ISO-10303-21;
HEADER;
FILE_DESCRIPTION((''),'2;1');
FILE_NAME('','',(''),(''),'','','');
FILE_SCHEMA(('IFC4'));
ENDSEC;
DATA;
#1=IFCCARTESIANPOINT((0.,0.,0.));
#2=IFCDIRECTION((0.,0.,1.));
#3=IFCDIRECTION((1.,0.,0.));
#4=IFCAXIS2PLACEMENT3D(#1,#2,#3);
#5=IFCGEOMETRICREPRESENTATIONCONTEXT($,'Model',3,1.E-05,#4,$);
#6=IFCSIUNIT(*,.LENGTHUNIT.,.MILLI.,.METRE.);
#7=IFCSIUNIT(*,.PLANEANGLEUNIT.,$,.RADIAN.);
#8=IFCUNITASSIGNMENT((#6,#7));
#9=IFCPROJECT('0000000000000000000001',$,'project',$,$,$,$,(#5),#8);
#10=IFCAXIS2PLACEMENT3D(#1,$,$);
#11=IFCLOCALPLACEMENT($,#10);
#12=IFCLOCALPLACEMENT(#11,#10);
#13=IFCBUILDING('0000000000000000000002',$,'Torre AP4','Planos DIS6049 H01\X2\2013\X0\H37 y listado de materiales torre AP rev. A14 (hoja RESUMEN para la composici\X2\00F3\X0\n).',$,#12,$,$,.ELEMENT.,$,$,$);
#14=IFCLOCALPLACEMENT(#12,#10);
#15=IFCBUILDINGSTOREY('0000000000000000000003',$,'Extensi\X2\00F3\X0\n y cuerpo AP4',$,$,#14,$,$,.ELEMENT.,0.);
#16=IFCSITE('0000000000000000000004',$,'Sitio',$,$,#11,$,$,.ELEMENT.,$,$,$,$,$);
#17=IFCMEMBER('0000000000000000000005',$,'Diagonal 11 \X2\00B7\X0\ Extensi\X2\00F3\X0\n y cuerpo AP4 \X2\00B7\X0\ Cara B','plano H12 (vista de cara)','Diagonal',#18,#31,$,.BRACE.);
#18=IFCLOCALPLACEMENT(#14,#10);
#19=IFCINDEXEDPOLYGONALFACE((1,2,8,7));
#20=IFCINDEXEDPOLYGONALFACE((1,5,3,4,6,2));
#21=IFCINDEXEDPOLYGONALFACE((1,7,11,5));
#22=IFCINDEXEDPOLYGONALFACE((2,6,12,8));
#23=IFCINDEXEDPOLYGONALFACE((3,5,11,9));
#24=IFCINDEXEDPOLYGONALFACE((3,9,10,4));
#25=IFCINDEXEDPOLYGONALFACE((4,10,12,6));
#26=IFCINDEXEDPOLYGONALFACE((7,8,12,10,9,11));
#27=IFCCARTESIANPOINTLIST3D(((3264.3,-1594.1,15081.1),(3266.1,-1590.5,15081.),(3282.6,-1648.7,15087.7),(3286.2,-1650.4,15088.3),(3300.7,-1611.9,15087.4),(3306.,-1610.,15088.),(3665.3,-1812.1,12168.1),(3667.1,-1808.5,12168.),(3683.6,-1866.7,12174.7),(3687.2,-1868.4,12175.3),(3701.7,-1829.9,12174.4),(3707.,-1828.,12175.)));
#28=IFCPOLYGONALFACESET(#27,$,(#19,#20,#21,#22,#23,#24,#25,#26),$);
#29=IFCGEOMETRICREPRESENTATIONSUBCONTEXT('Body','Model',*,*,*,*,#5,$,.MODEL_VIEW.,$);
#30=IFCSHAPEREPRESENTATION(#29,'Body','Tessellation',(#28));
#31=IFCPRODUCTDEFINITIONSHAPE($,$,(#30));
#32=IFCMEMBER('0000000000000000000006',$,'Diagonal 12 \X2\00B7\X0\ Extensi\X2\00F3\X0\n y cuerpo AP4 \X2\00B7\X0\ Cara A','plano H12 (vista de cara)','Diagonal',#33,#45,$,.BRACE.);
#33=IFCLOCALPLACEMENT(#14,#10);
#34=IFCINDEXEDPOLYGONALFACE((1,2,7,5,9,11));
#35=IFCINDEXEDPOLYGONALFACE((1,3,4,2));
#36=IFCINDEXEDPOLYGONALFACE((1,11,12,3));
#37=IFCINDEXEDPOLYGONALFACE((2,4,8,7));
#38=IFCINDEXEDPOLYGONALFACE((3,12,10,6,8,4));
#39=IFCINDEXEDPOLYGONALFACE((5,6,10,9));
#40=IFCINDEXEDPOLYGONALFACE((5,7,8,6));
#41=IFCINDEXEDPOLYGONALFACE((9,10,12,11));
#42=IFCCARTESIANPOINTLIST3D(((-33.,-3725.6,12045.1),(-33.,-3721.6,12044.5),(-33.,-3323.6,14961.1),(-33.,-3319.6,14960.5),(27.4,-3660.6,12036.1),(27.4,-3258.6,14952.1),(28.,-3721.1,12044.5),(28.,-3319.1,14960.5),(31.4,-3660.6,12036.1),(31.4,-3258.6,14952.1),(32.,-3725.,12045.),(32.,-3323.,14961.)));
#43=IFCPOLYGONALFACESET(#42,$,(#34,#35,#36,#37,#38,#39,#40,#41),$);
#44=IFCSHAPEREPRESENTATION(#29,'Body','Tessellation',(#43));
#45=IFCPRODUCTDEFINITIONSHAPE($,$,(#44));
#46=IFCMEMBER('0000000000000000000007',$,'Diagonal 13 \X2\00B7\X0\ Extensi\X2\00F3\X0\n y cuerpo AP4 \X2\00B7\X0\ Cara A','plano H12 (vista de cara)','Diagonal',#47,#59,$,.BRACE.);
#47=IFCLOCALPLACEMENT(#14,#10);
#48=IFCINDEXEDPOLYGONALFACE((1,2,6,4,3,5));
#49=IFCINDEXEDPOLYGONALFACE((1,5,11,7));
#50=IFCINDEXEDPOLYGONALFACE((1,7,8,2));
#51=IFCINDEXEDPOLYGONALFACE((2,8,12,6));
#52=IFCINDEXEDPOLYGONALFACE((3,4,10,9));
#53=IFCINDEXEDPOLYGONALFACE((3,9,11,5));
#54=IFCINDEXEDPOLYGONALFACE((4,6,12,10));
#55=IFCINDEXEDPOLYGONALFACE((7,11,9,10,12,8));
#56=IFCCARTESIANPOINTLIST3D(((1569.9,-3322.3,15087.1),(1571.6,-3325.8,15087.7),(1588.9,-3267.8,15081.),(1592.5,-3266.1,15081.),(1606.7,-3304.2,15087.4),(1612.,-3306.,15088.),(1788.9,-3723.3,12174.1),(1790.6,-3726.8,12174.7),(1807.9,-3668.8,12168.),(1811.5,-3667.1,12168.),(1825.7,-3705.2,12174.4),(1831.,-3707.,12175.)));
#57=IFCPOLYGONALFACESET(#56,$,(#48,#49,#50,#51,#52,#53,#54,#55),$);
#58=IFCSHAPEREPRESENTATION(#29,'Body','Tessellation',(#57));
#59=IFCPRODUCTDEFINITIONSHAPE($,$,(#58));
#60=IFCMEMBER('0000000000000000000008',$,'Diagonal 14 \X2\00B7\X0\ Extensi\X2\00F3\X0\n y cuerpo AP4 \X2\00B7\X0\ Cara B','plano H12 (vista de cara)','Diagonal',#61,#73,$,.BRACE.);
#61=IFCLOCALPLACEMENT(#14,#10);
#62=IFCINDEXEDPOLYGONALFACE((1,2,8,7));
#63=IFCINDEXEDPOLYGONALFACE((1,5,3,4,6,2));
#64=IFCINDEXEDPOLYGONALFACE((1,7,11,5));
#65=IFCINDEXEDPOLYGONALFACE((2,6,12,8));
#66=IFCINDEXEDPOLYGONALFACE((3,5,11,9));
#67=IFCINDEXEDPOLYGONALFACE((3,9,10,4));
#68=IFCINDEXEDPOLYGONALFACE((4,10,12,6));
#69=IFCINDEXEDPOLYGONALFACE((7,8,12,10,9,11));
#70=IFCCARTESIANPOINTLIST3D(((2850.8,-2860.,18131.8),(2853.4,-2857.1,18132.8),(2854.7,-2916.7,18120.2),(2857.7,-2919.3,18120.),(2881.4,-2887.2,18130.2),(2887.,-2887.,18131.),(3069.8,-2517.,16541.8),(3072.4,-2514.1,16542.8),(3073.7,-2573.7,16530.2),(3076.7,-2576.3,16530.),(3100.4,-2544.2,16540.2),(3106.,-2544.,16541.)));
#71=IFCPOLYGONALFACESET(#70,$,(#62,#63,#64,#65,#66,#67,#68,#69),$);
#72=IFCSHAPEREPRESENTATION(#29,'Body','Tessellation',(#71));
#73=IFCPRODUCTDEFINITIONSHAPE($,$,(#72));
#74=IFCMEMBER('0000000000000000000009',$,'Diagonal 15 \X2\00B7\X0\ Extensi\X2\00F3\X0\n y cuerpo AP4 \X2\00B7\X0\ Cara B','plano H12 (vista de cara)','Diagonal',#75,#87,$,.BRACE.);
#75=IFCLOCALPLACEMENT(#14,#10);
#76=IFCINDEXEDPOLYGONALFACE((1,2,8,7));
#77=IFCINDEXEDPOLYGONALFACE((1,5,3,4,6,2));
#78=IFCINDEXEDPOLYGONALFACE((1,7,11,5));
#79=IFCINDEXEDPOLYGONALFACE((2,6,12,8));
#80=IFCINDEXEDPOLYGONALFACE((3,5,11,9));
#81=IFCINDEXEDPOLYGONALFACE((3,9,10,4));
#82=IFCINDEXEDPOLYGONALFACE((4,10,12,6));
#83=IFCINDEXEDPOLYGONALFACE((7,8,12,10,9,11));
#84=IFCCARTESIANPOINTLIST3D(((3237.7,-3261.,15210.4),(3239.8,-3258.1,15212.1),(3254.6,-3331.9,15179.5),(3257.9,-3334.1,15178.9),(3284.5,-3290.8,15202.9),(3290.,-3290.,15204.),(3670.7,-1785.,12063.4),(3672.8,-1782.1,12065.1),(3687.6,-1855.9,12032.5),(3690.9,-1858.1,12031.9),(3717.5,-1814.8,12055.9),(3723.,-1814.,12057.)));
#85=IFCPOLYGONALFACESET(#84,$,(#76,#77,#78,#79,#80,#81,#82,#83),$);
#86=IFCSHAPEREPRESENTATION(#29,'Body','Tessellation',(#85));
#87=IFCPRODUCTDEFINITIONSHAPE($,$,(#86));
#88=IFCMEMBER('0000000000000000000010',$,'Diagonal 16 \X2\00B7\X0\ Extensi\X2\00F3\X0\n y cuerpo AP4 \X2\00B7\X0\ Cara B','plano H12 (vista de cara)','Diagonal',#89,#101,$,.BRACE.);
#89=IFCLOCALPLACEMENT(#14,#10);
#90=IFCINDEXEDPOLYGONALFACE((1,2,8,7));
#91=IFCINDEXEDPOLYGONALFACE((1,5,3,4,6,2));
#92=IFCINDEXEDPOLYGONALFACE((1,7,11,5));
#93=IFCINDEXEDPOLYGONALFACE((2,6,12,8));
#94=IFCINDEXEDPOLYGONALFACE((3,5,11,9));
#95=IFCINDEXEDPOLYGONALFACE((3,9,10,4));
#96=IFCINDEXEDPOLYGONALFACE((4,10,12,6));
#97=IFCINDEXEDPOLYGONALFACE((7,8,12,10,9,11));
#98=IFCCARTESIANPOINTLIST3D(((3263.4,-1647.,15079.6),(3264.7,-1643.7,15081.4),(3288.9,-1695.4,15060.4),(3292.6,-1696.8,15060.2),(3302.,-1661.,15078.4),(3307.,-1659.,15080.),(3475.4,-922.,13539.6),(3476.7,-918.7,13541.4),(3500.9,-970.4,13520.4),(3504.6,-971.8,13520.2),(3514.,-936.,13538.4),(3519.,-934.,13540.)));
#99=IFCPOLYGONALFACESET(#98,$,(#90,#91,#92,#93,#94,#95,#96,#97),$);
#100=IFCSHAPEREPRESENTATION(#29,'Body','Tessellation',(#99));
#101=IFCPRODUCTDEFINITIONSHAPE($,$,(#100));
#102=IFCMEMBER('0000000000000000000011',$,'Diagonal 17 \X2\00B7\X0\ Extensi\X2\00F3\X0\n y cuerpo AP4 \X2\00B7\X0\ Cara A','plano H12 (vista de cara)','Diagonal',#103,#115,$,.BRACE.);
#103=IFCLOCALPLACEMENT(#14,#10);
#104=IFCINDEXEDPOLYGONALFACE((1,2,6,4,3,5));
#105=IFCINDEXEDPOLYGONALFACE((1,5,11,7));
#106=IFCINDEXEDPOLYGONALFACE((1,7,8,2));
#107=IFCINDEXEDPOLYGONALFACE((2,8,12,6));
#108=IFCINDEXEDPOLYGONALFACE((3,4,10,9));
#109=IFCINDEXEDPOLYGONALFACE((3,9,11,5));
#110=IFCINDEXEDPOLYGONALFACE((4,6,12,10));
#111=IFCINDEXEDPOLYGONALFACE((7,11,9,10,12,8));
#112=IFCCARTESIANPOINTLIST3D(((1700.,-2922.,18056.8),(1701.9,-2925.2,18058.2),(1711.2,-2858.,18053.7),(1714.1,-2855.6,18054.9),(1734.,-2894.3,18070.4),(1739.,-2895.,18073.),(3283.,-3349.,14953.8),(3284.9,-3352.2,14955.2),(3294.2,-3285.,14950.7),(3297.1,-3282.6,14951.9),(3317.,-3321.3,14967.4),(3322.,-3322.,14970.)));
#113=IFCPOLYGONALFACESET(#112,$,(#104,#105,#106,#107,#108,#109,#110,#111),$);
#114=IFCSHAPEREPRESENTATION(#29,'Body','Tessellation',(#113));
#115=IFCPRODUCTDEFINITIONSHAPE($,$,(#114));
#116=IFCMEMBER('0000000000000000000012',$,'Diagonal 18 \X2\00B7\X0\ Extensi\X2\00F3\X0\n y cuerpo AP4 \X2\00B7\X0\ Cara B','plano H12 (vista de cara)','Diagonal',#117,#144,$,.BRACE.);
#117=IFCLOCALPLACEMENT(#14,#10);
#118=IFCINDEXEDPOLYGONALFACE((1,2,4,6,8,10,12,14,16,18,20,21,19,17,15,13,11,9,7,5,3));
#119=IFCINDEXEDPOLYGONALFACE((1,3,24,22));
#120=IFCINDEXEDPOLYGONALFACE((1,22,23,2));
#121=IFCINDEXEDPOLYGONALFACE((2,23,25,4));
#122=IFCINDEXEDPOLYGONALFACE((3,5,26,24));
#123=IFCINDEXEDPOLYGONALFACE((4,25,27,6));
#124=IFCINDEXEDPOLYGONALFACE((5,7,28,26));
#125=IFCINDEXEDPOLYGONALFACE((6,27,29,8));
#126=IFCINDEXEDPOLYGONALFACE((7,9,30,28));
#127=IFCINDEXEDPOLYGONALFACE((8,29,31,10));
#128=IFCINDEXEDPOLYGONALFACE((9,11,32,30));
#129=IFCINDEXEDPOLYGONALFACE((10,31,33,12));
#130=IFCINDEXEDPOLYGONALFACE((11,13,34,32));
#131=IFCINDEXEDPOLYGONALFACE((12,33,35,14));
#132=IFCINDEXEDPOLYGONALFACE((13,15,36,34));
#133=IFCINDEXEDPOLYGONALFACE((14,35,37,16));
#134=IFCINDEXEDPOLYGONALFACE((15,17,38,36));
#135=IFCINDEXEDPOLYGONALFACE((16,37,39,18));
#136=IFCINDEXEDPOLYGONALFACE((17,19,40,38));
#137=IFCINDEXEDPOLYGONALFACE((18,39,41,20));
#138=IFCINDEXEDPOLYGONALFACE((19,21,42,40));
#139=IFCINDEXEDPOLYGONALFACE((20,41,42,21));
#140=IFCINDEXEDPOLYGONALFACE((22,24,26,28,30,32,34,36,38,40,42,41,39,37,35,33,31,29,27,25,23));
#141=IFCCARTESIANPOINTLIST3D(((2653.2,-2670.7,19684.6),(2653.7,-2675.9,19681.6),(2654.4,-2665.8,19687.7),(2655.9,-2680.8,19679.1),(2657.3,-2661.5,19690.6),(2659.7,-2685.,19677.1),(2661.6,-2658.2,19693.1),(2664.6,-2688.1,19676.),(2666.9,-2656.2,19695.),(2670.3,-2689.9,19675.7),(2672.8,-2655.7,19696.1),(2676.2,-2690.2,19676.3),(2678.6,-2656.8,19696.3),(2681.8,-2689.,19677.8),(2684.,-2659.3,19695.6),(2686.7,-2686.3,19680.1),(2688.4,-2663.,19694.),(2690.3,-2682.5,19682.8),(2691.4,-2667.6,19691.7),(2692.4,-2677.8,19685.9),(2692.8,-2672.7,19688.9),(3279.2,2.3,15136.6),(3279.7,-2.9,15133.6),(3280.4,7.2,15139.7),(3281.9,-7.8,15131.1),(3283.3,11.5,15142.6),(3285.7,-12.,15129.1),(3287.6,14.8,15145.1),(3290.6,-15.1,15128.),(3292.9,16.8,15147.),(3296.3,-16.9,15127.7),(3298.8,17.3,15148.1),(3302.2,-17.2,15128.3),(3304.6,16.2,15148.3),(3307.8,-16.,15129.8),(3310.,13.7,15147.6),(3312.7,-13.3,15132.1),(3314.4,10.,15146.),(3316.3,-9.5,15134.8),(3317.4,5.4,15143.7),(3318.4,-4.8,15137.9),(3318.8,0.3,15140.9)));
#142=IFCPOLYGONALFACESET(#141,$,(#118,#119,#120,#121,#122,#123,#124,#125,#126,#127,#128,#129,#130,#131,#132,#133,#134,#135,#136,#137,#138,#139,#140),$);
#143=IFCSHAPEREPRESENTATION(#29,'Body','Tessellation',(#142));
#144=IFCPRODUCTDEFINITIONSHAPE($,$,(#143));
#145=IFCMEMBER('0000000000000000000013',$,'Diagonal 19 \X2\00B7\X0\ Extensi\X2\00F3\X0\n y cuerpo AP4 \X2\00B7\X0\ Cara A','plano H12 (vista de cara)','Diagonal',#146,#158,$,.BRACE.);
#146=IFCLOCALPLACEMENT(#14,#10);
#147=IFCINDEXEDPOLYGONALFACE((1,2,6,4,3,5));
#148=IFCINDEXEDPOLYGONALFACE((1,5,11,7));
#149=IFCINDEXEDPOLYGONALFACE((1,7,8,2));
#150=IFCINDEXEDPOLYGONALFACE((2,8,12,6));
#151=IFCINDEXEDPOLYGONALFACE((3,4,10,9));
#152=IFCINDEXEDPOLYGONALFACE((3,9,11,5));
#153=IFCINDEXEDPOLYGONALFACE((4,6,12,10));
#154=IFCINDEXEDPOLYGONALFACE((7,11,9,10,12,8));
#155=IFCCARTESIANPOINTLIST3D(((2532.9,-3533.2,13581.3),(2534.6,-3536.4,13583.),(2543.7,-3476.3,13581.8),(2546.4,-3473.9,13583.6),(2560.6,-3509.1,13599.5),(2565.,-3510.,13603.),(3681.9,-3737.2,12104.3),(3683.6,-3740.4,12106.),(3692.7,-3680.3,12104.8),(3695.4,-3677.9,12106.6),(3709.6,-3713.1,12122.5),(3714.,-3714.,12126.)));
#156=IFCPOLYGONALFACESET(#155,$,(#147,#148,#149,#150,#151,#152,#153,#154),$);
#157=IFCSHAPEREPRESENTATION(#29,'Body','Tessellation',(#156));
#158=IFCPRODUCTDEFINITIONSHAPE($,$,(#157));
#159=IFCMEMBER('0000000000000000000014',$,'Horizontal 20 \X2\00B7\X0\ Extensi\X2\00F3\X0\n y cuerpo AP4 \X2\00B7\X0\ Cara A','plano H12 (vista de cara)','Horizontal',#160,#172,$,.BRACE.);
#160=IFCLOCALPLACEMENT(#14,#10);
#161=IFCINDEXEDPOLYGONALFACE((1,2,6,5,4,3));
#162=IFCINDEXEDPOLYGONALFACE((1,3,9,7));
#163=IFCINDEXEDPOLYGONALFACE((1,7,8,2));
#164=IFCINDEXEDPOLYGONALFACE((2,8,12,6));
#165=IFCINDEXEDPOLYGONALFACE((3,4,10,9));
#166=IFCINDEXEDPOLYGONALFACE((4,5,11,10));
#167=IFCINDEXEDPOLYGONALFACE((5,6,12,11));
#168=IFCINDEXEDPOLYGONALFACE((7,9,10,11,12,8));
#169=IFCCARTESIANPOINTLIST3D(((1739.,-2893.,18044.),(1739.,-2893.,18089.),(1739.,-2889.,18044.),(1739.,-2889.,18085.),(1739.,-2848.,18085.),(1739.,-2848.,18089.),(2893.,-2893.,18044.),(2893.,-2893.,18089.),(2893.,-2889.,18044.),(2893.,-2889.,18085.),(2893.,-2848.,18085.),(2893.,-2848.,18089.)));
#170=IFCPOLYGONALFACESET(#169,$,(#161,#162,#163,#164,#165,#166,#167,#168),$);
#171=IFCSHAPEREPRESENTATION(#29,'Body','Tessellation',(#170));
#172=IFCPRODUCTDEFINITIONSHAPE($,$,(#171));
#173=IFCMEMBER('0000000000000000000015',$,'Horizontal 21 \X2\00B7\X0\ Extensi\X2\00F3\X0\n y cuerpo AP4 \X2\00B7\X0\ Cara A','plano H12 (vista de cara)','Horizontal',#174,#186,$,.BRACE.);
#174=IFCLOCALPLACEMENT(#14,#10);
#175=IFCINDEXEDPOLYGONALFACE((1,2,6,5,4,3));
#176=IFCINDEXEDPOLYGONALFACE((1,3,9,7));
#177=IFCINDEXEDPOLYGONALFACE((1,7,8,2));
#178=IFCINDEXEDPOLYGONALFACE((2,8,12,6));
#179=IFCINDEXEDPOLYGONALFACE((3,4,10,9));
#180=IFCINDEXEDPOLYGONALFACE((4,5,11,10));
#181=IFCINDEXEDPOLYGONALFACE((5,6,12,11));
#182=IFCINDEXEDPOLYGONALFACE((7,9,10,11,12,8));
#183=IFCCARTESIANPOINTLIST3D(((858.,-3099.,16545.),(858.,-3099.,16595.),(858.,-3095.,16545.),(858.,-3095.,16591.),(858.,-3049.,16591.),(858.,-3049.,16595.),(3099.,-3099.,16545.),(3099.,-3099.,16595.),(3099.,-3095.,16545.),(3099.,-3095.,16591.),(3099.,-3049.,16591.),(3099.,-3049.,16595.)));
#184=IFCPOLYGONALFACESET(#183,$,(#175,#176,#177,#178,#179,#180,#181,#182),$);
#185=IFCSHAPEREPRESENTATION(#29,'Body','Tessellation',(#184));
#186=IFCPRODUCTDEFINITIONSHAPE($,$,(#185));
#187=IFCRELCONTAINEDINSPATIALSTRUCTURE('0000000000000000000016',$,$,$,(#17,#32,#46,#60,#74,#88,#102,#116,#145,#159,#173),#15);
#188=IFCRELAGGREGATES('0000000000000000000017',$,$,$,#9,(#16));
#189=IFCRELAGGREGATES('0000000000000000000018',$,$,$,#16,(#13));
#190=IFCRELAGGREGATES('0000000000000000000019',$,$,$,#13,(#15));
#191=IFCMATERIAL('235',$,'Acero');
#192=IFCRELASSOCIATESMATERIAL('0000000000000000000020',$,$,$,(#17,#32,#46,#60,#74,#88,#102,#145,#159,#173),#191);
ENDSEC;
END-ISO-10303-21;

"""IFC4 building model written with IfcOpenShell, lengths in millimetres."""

from ifc_helpers import new_model, si_unit, frame, frame_2d, origin, origin_with_axes, place, context, subcontext, project, spatial, circle, l_section, extrude, material, element, save


model = new_model("IFC4")

# Units and contexts
model_context = context("Model", 3, precision=1e-05, world=origin_with_axes())
body_context = subcontext(model_context, "Body", "Model", "MODEL_VIEW")
ifc_project = project(units=[si_unit("LENGTHUNIT", "METRE", prefix="MILLI"), si_unit("PLANEANGLEUNIT", "RADIAN")], contexts=[model_context])

# Site, building, storey
site_placement = place(None, origin())
site = spatial("IfcSite", under=ifc_project, at=site_placement, Name="Sitio", CompositionType="ELEMENT")
building_placement = place(site_placement, origin())
building = spatial("IfcBuilding", under=site, at=building_placement, Name="Torre AP4", Description="Planos DIS6049 H01–H37 y listado de materiales torre AP rev. A14 (hoja RESUMEN para la composición).", CompositionType="ELEMENT")
storey_placement = place(building_placement, origin())
storey = spatial("IfcBuildingStorey", under=building, at=storey_placement, Name="Extensión y cuerpo AP4", CompositionType="ELEMENT", Elevation=0.0)

# Members
ifc_material_1 = material(Name="235", Category="Acero")
member_1_placement = place(storey_placement, frame((3707.0, -1828.0, 12175.0), z_axis=(-0.135999, 0.073935, 0.987946), x_axis=(-0.887553, 0.43397, -0.154657)))
element("IfcMember", 1, at=member_1_placement, inside=storey, material=ifc_material_1, Name="Diagonal 11 · Extensión y cuerpo AP4 · Cara B", Description="plano H12 (vista de cara)", ObjectType="Diagonal", PredefinedType="BRACE", context=body_context, shape_type="SweptSolid", body=[
    extrude(l_section(Depth=45.0, Width=45.0, Thickness=4.0, at=frame_2d((22.5, 22.5))), None, (0.0, 0.0, 1.0), 2948.5),
])
member_2_placement = place(storey_placement, frame((32.0, -3725.0, 12045.0), z_axis=(0.0, 0.136568, 0.990631), x_axis=(-0.009166, 0.990589, -0.136563)))
element("IfcMember", 2, at=member_2_placement, inside=storey, material=ifc_material_1, Name="Diagonal 12 · Extensión y cuerpo AP4 · Cara A", Description="plano H12 (vista de cara)", ObjectType="Diagonal", PredefinedType="BRACE", context=body_context, shape_type="SweptSolid", body=[
    extrude(l_section(Depth=65.0, Width=65.0, Thickness=4.0, at=frame_2d((32.5, 32.5))), None, (0.0, 0.0, 1.0), 2943.6),
])
member_3_placement = place(storey_placement, frame((1831.0, -3707.0, 12175.0), z_axis=(-0.074272, 0.135996, 0.987921), x_axis=(-0.434439, 0.887298, -0.154806)))
element("IfcMember", 3, at=member_3_placement, inside=storey, material=ifc_material_1, Name="Diagonal 13 · Extensión y cuerpo AP4 · Cara A", Description="plano H12 (vista de cara)", ObjectType="Diagonal", PredefinedType="BRACE", context=body_context, shape_type="SweptSolid", body=[
    extrude(l_section(Depth=45.0, Width=45.0, Thickness=4.0, at=frame_2d((22.5, 22.5))), None, (0.0, 0.0, 1.0), 2948.6),
])
member_4_placement = place(storey_placement, frame((3106.0, -2544.0, 16541.0), z_axis=(-0.133435, -0.208987, 0.968772), x_axis=(-0.747172, 0.663414, 0.040202)))
element("IfcMember", 4, at=member_4_placement, inside=storey, material=ifc_material_1, Name="Diagonal 14 · Extensión y cuerpo AP4 · Cara B", Description="plano H12 (vista de cara)", ObjectType="Diagonal", PredefinedType="BRACE", context=body_context, shape_type="SweptSolid", body=[
    extrude(l_section(Depth=45.0, Width=45.0, Thickness=4.0, at=frame_2d((22.5, 22.5))), None, (0.0, 0.0, 1.0), 1641.3),
])
member_5_placement = place(storey_placement, frame((3723.0, -1814.0, 12057.0), z_axis=(-0.123615, -0.421376, 0.898422), x_axis=(-0.836041, 0.531937, 0.134456)))
element("IfcMember", 5, at=member_5_placement, inside=storey, material=ifc_material_1, Name="Diagonal 15 · Extensión y cuerpo AP4 · Cara B", Description="plano H12 (vista de cara)", ObjectType="Diagonal", PredefinedType="BRACE", context=body_context, shape_type="SweptSolid", body=[
    extrude(l_section(Depth=60.0, Width=60.0, Thickness=4.0, at=frame_2d((30.0, 30.0))), None, (0.0, 0.0, 1.0), 3502.8),
])
member_6_placement = place(storey_placement, frame((3519.0, -934.0, 13540.0), z_axis=(-0.123595, -0.422673, 0.897815), x_axis=(-0.939656, 0.34071, 0.031044)))
element("IfcMember", 6, at=member_6_placement, inside=storey, material=ifc_material_1, Name="Diagonal 16 · Extensión y cuerpo AP4 · Cara B", Description="plano H12 (vista de cara)", ObjectType="Diagonal", PredefinedType="BRACE", context=body_context, shape_type="SweptSolid", body=[
    extrude(l_section(Depth=45.0, Width=45.0, Thickness=4.0, at=frame_2d((22.5, 22.5))), None, (0.0, 0.0, 1.0), 1715.3),
])
member_7_placement = place(storey_placement, frame((3322.0, -3322.0, 14970.0), z_axis=(-0.451057, 0.121669, 0.884163), x_axis=(-0.497452, 0.788239, -0.362244)))
element("IfcMember", 7, at=member_7_placement, inside=storey, material=ifc_material_1, Name="Diagonal 17 · Extensión y cuerpo AP4 · Cara A", Description="plano H12 (vista de cara)", ObjectType="Diagonal", PredefinedType="BRACE", context=body_context, shape_type="SweptSolid", body=[
    extrude(l_section(Depth=50.0, Width=50.0, Thickness=4.0, at=frame_2d((25.0, 25.0))), None, (0.0, 0.0, 1.0), 3509.5),
])
member_8_placement = place(storey_placement, frame((3299.0, 0.0, 15138.0), z_axis=(-0.117839, -0.503167, 0.856118), x_axis=(-0.928763, 0.360959, 0.084309)))
element("IfcMember", 8, at=member_8_placement, inside=storey, Name="Diagonal 18 · Extensión y cuerpo AP4 · Cara B", Description="plano H12 (vista de cara)", ObjectType="Diagonal", PredefinedType="BRACE", context=body_context, shape_type="SweptSolid", body=[
    extrude(circle(Radius=20.0), None, (0.0, 0.0, 1.0), 5312.4),
])
member_9_placement = place(storey_placement, frame((3714.0, -3714.0, 12126.0), z_axis=(-0.610398, 0.108374, 0.784646), x_axis=(-0.412839, 0.801882, -0.431913)))
element("IfcMember", 9, at=member_9_placement, inside=storey, material=ifc_material_1, Name="Diagonal 19 · Extensión y cuerpo AP4 · Cara A", Description="plano H12 (vista de cara)", ObjectType="Diagonal", PredefinedType="BRACE", context=body_context, shape_type="SweptSolid", body=[
    extrude(l_section(Depth=45.0, Width=45.0, Thickness=4.0, at=frame_2d((22.5, 22.5))), None, (0.0, 0.0, 1.0), 1882.4),
])
member_10_placement = place(storey_placement, frame((2893.0, -2893.0, 18089.0), z_axis=(-1.0, 0.0, 0.0), x_axis=(0.0, 1.0, 0.0)))
element("IfcMember", 10, at=member_10_placement, inside=storey, material=ifc_material_1, Name="Horizontal 20 · Extensión y cuerpo AP4 · Cara A", Description="plano H12 (vista de cara)", ObjectType="Horizontal", PredefinedType="BRACE", context=body_context, shape_type="SweptSolid", body=[
    extrude(l_section(Depth=45.0, Width=45.0, Thickness=4.0, at=frame_2d((22.5, 22.5))), None, (0.0, 0.0, 1.0), 1154.0),
])
member_11_placement = place(storey_placement, frame((3099.0, -3099.0, 16595.0), z_axis=(-1.0, 0.0, 0.0), x_axis=(0.0, 1.0, 0.0)))
element("IfcMember", 11, at=member_11_placement, inside=storey, material=ifc_material_1, Name="Horizontal 21 · Extensión y cuerpo AP4 · Cara A", Description="plano H12 (vista de cara)", ObjectType="Horizontal", PredefinedType="BRACE", context=body_context, shape_type="SweptSolid", body=[
    extrude(l_section(Depth=50.0, Width=50.0, Thickness=4.0, at=frame_2d((25.0, 25.0))), None, (0.0, 0.0, 1.0), 2241.0),
])

save(model, "model.ifc")
